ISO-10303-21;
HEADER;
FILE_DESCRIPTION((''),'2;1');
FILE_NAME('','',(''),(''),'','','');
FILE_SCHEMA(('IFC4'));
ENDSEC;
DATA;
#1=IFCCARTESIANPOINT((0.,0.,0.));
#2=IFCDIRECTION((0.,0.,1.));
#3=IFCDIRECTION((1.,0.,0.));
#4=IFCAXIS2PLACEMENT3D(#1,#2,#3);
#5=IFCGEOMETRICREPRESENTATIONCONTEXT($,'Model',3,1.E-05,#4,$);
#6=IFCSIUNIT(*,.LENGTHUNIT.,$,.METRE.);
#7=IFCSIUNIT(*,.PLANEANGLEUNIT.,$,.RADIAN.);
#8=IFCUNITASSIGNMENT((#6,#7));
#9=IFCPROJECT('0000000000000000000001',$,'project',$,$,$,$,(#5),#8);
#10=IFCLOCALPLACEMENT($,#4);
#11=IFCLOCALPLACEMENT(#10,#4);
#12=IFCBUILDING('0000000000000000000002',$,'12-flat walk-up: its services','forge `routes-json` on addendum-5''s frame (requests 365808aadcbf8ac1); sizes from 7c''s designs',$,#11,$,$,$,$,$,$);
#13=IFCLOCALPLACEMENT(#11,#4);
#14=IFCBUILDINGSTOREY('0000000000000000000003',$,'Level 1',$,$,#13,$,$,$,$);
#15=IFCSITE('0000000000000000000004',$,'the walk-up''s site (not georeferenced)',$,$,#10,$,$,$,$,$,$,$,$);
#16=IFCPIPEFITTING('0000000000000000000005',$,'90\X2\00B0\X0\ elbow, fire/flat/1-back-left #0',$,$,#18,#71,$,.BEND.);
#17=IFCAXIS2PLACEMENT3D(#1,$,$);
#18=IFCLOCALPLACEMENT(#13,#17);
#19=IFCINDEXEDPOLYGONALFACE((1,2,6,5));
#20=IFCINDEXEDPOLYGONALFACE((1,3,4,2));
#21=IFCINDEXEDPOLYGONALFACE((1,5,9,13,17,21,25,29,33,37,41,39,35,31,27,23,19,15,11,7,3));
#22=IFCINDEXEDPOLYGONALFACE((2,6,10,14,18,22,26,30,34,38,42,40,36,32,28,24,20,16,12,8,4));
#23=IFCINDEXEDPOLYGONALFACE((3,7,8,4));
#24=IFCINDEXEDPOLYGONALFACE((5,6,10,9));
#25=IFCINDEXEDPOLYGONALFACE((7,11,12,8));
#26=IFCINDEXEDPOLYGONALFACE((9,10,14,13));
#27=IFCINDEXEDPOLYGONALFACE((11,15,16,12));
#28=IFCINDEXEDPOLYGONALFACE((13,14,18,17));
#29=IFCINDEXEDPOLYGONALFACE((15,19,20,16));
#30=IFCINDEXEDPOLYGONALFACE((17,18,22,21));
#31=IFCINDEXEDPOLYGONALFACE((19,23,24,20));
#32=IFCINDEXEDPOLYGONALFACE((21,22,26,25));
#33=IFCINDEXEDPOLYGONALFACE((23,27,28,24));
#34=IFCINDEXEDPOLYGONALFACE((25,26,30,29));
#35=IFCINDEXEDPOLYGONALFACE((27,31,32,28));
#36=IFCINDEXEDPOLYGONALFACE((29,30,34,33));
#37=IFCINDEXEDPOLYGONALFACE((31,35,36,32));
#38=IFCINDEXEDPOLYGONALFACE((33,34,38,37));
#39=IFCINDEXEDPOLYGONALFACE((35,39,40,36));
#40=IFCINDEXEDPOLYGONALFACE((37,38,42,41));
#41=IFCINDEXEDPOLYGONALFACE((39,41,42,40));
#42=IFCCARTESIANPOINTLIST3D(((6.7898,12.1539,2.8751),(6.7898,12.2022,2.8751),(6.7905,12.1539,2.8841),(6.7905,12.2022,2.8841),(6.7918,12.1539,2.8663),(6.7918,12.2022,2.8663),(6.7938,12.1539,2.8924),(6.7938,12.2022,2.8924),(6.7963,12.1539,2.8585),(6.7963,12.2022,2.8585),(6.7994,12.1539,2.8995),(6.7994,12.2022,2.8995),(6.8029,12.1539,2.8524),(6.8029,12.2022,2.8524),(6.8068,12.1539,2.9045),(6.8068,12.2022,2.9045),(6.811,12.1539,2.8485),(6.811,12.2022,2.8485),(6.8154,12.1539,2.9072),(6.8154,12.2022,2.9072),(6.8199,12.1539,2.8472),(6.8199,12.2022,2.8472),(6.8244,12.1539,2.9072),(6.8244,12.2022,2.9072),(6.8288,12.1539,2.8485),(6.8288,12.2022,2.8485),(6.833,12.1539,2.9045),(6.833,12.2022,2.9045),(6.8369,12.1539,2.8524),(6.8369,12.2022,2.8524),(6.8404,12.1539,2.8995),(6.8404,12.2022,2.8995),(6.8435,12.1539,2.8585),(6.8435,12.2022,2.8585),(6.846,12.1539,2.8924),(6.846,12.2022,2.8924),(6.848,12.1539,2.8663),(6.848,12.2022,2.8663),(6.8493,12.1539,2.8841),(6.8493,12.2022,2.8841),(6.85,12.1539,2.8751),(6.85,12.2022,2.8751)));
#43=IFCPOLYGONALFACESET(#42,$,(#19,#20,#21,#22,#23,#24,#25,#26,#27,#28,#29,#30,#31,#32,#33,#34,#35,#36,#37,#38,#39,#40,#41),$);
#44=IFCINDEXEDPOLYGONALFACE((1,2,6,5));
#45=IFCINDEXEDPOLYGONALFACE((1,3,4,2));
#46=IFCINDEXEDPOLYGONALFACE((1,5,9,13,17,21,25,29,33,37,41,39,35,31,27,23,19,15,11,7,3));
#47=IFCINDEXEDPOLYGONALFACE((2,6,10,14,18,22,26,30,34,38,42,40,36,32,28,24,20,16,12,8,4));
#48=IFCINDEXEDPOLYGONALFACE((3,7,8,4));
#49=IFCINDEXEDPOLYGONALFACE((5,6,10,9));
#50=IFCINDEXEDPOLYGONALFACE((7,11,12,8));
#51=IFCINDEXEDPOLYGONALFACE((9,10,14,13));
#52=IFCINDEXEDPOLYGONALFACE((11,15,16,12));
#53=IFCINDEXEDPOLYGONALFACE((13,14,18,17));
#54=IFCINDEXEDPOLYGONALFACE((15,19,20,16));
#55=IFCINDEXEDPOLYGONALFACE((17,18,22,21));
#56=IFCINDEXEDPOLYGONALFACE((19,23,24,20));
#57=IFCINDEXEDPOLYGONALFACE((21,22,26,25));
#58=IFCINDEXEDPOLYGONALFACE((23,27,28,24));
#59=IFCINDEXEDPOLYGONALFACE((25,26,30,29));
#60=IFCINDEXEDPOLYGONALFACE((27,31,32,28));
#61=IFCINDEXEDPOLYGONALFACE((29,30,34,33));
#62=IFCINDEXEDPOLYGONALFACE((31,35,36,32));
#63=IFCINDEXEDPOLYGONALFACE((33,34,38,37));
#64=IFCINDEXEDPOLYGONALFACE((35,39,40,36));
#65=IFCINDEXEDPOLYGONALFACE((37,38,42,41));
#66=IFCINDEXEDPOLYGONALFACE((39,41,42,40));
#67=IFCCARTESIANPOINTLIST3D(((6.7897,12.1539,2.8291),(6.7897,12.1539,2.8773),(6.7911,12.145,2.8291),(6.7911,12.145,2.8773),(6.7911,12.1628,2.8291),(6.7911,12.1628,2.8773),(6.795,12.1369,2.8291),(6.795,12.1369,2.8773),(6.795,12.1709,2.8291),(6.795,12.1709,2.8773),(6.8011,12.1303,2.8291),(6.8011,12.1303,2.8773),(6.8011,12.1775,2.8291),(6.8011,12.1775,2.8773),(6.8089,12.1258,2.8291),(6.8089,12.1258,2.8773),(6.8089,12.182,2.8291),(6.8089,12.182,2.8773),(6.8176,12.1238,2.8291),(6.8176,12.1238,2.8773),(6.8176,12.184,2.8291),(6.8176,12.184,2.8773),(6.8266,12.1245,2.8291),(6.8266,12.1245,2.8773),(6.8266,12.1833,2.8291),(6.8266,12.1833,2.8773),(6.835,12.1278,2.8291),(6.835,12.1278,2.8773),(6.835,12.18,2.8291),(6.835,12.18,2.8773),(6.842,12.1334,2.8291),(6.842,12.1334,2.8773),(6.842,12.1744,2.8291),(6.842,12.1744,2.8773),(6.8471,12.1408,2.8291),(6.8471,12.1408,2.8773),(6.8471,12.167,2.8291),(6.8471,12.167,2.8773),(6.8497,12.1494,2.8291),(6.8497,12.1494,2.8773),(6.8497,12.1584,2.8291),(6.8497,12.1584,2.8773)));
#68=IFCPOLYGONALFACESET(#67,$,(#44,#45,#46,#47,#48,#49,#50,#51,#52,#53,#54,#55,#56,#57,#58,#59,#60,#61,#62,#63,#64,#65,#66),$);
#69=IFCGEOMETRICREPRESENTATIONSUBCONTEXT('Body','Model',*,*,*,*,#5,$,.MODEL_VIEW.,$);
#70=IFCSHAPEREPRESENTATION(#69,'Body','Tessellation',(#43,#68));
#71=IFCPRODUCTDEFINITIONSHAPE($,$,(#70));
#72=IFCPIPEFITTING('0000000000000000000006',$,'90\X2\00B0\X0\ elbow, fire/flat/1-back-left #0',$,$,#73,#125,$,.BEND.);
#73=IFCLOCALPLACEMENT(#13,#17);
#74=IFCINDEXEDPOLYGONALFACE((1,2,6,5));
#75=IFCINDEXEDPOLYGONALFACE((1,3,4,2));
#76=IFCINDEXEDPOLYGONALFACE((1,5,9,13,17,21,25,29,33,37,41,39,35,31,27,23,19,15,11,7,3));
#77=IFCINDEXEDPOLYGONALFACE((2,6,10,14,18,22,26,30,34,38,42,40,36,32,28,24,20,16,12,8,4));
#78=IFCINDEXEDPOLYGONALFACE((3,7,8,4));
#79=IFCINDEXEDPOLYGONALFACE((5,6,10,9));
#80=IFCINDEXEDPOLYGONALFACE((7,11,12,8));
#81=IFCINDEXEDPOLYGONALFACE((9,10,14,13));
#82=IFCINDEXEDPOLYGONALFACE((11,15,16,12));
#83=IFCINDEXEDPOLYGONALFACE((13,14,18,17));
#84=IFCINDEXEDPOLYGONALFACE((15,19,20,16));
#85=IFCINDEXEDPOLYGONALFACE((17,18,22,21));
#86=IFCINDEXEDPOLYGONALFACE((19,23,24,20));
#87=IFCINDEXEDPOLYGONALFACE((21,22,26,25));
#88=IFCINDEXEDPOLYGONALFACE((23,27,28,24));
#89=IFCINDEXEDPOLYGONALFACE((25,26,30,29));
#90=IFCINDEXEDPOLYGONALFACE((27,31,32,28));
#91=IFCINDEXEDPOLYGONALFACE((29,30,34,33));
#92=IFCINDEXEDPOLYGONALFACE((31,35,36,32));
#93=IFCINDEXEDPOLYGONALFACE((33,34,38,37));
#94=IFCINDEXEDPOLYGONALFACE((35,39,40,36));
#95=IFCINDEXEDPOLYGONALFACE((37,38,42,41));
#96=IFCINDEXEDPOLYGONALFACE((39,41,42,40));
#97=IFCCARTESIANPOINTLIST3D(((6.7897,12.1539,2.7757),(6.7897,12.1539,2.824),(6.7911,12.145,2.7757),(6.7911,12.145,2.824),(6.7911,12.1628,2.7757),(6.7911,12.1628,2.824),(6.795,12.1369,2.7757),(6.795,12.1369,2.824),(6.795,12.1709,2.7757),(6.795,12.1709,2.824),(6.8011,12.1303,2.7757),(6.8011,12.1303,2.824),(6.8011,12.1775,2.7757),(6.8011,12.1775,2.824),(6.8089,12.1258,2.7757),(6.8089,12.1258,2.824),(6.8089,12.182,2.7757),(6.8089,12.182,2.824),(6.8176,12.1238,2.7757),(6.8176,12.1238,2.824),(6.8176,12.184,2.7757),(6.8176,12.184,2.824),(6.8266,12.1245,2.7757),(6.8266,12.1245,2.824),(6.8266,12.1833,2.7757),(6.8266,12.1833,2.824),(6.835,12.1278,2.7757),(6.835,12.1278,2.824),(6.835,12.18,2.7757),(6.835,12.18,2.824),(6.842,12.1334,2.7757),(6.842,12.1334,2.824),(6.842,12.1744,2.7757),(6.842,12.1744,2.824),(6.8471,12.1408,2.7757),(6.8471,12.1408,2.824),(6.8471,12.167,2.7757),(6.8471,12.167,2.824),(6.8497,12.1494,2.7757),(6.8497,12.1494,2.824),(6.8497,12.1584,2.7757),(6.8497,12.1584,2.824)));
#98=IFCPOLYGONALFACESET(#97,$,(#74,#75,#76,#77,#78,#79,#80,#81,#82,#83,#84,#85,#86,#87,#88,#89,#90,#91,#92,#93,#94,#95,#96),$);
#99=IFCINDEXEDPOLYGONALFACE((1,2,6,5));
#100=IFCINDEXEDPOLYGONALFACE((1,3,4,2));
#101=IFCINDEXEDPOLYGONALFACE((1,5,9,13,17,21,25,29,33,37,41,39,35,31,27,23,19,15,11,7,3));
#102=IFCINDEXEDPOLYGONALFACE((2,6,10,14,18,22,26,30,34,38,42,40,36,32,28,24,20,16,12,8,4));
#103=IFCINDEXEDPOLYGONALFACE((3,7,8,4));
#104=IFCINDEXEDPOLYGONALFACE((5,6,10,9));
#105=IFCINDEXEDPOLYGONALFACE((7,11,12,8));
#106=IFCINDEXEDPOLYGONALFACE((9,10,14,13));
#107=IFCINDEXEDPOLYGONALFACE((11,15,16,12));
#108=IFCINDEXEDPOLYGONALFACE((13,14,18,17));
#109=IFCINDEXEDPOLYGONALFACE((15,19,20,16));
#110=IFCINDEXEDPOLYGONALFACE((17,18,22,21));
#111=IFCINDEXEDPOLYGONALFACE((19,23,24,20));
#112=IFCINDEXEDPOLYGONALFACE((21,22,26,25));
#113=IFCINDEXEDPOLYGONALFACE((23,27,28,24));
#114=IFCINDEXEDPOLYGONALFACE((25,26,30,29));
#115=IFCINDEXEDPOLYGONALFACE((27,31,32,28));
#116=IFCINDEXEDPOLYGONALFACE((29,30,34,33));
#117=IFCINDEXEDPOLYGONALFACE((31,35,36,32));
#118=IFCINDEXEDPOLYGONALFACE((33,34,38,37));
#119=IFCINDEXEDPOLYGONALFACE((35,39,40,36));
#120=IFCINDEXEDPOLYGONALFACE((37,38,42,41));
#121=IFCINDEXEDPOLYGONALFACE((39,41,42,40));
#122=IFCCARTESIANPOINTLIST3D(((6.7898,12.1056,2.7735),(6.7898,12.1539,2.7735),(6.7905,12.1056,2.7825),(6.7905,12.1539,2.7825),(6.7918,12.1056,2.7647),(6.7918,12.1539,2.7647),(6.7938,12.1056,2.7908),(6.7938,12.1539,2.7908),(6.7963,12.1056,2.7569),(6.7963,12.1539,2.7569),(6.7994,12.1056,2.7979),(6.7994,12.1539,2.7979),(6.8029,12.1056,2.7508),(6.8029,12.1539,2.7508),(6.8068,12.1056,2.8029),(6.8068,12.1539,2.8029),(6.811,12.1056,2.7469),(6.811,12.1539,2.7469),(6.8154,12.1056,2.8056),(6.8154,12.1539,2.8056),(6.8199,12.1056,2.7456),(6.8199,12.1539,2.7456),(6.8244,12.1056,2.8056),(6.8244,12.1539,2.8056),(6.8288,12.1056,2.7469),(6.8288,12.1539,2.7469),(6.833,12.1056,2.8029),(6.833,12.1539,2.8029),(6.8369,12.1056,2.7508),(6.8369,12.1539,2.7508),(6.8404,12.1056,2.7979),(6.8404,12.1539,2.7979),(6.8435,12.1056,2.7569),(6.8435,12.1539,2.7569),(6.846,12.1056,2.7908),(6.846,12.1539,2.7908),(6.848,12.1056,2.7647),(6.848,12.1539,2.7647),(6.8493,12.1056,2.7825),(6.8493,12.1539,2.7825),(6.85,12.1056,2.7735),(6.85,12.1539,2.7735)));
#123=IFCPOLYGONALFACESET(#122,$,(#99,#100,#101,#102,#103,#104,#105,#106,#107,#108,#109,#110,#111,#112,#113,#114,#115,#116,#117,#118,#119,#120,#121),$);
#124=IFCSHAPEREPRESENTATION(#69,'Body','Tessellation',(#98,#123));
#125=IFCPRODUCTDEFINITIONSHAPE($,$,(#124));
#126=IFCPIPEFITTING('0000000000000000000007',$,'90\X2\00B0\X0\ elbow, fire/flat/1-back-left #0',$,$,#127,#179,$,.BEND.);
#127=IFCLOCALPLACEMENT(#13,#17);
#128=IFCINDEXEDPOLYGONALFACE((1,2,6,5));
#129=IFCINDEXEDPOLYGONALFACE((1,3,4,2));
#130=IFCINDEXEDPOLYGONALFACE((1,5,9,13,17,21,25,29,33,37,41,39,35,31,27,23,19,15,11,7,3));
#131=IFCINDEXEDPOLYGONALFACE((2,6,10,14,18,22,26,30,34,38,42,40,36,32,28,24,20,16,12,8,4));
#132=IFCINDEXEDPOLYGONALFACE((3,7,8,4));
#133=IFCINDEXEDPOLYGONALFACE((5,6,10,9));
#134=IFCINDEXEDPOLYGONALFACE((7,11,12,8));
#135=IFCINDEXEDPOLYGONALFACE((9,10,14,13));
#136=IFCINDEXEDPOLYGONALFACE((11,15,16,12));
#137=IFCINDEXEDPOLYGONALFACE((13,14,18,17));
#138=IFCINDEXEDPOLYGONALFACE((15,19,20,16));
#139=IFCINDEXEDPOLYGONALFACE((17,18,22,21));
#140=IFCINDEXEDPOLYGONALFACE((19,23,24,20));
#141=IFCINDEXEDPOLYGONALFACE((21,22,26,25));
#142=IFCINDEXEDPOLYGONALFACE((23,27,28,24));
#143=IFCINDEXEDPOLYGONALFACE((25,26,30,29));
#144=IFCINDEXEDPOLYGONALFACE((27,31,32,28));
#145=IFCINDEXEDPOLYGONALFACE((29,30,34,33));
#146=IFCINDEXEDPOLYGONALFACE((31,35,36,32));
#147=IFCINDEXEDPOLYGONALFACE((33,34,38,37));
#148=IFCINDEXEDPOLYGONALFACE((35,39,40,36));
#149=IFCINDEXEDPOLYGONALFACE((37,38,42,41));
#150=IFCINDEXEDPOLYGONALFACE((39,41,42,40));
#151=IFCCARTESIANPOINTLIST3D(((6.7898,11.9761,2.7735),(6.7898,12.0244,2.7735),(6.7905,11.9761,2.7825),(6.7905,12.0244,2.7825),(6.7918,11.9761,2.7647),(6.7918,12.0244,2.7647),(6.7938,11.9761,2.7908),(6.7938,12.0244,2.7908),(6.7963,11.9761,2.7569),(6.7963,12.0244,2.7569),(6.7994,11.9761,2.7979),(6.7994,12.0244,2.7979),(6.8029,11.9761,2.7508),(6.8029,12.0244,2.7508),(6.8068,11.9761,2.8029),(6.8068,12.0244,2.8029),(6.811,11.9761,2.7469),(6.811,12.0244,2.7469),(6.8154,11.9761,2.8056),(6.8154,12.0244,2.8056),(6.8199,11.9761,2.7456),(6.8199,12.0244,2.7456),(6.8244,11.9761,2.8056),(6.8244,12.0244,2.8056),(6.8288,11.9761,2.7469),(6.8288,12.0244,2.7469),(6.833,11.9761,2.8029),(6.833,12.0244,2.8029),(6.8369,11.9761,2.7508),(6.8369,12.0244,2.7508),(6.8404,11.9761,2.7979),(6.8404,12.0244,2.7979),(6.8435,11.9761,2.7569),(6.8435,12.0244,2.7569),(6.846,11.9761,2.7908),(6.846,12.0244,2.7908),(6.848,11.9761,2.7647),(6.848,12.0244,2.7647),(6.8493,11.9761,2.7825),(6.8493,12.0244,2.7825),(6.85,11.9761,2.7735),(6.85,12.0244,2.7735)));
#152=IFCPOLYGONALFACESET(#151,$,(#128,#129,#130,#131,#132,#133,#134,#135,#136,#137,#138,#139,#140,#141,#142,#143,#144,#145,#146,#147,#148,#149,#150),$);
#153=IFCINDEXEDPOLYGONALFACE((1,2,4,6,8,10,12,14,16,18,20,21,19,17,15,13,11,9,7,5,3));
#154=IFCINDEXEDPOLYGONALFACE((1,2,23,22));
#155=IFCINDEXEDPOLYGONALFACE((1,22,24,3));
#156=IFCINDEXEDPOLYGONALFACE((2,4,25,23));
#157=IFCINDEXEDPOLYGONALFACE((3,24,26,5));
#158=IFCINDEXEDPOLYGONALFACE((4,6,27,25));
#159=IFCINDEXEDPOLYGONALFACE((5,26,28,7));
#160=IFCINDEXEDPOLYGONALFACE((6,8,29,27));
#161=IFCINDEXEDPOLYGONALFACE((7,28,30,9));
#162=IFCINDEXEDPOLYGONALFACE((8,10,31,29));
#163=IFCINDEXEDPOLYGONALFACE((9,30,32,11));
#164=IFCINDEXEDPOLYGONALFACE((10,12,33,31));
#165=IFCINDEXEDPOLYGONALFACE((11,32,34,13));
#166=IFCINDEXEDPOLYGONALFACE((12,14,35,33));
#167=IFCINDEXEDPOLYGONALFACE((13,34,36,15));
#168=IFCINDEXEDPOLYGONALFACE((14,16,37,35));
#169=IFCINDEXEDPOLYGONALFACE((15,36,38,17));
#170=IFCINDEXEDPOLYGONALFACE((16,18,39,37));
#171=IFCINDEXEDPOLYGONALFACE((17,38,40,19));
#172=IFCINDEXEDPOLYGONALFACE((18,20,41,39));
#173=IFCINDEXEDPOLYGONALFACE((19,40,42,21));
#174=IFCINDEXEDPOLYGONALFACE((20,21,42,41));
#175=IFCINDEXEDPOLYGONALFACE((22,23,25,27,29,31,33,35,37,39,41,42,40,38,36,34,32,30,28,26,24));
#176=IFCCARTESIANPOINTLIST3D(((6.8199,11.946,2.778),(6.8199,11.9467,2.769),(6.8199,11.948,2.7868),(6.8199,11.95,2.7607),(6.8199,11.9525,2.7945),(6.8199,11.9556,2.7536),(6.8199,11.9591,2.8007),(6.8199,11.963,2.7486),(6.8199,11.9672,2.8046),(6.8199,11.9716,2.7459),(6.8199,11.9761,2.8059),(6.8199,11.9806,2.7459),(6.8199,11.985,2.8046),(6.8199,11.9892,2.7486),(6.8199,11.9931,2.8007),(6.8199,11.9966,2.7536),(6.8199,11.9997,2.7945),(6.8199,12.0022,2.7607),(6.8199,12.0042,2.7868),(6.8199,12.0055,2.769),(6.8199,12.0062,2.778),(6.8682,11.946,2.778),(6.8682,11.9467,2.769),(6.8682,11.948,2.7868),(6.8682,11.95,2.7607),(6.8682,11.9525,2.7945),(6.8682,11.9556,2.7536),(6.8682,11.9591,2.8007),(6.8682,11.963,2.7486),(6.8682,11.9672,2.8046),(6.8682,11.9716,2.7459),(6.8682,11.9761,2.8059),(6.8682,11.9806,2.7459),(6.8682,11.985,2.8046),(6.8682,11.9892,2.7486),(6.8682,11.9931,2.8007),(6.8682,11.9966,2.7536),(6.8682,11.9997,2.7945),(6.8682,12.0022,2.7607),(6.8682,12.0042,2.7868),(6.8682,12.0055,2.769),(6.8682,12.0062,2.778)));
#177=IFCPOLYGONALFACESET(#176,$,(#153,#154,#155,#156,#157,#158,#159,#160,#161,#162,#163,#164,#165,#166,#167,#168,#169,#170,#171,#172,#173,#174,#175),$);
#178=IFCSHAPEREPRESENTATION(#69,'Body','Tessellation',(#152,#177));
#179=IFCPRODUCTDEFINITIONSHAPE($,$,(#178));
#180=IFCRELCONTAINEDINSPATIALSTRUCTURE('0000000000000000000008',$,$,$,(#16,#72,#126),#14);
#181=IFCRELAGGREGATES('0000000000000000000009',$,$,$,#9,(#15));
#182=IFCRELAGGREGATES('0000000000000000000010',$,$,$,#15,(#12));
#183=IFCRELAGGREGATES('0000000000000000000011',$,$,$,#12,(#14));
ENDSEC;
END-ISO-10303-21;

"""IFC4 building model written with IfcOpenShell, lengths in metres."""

from ifc_helpers import new_model, entity, si_unit, frame, origin_with_axes, place, context, subcontext, project, spatial, element, save


model = new_model("IFC4")

# Units and contexts
model_context = context("Model", 3, precision=1e-05, world=origin_with_axes())
body_context = subcontext(model_context, "Body", "Model", "MODEL_VIEW")
ifc_project = project(units=[si_unit("LENGTHUNIT", "METRE"), si_unit("PLANEANGLEUNIT", "RADIAN")], contexts=[model_context])

# Site, building, storey
site_placement = place(None, origin_with_axes())
site = spatial("IfcSite", under=ifc_project, at=site_placement, Name="the walk-up's site (not georeferenced)")
building_placement = place(site_placement, origin_with_axes())
building = spatial("IfcBuilding", under=site, at=building_placement, Name="12-flat walk-up: its services", Description="forge `routes-json` on addendum-5's frame (requests 365808aadcbf8ac1); sizes from 7c's designs")
storey_placement = place(building_placement, origin_with_axes())
storey = spatial("IfcBuildingStorey", under=building, at=storey_placement, Name="Level 1")

# Pipe fittings
pipe_fitting_1_placement = place(storey_placement, frame((6.8199, 12.2022, 2.8773), z_axis=(0.0, 0.0, 1.0), x_axis=(1.0, 0.0, 0.0)))
element("IfcPipeFitting", 1, at=pipe_fitting_1_placement, inside=storey, Name="90° elbow, fire/flat/1-back-left #0", PredefinedType="BEND", context=body_context, shape_type="AdvancedSweptSolid", body=[
    entity("IfcSweptDiskSolid", entity("IfcPolyline", [entity("IfcCartesianPoint", [0.0, 0.0, 0.0]), entity("IfcCartesianPoint", [0.0, -0.0483, 0.0])]), 0.0302),
    entity("IfcSweptDiskSolid", entity("IfcPolyline", [entity("IfcCartesianPoint", [0.0, -0.0483, 0.0]), entity("IfcCartesianPoint", [0.0, -0.0483, -0.0483])]), 0.0302),
])
pipe_fitting_2_placement = place(storey_placement, frame((6.8199, 12.1539, 2.824), z_axis=(0.0, 0.0, 1.0), x_axis=(1.0, 0.0, 0.0)))
element("IfcPipeFitting", 2, at=pipe_fitting_2_placement, inside=storey, Name="90° elbow, fire/flat/1-back-left #0", PredefinedType="BEND", context=body_context, shape_type="AdvancedSweptSolid", body=[
    entity("IfcSweptDiskSolid", entity("IfcPolyline", [entity("IfcCartesianPoint", [0.0, 0.0, 0.0]), entity("IfcCartesianPoint", [0.0, 0.0, -0.0483])]), 0.0302),
    entity("IfcSweptDiskSolid", entity("IfcPolyline", [entity("IfcCartesianPoint", [0.0, 0.0, -0.0483]), entity("IfcCartesianPoint", [0.0, -0.0483, -0.0483])]), 0.0302),
])
pipe_fitting_3_placement = place(storey_placement, frame((6.8199, 12.0244, 2.7757), z_axis=(0.0, 0.0, 1.0), x_axis=(1.0, 0.0, 0.0)))
element("IfcPipeFitting", 3, at=pipe_fitting_3_placement, inside=storey, Name="90° elbow, fire/flat/1-back-left #0", PredefinedType="BEND", context=body_context, shape_type="AdvancedSweptSolid", body=[
    entity("IfcSweptDiskSolid", entity("IfcPolyline", [entity("IfcCartesianPoint", [0.0, 0.0, 0.0]), entity("IfcCartesianPoint", [0.0, -0.0483, 0.0])]), 0.0302),
    entity("IfcSweptDiskSolid", entity("IfcPolyline", [entity("IfcCartesianPoint", [0.0, -0.0483, 0.0]), entity("IfcCartesianPoint", [0.0483, -0.0483, 0.0])]), 0.0302),
])

save(model, "model.ifc")
